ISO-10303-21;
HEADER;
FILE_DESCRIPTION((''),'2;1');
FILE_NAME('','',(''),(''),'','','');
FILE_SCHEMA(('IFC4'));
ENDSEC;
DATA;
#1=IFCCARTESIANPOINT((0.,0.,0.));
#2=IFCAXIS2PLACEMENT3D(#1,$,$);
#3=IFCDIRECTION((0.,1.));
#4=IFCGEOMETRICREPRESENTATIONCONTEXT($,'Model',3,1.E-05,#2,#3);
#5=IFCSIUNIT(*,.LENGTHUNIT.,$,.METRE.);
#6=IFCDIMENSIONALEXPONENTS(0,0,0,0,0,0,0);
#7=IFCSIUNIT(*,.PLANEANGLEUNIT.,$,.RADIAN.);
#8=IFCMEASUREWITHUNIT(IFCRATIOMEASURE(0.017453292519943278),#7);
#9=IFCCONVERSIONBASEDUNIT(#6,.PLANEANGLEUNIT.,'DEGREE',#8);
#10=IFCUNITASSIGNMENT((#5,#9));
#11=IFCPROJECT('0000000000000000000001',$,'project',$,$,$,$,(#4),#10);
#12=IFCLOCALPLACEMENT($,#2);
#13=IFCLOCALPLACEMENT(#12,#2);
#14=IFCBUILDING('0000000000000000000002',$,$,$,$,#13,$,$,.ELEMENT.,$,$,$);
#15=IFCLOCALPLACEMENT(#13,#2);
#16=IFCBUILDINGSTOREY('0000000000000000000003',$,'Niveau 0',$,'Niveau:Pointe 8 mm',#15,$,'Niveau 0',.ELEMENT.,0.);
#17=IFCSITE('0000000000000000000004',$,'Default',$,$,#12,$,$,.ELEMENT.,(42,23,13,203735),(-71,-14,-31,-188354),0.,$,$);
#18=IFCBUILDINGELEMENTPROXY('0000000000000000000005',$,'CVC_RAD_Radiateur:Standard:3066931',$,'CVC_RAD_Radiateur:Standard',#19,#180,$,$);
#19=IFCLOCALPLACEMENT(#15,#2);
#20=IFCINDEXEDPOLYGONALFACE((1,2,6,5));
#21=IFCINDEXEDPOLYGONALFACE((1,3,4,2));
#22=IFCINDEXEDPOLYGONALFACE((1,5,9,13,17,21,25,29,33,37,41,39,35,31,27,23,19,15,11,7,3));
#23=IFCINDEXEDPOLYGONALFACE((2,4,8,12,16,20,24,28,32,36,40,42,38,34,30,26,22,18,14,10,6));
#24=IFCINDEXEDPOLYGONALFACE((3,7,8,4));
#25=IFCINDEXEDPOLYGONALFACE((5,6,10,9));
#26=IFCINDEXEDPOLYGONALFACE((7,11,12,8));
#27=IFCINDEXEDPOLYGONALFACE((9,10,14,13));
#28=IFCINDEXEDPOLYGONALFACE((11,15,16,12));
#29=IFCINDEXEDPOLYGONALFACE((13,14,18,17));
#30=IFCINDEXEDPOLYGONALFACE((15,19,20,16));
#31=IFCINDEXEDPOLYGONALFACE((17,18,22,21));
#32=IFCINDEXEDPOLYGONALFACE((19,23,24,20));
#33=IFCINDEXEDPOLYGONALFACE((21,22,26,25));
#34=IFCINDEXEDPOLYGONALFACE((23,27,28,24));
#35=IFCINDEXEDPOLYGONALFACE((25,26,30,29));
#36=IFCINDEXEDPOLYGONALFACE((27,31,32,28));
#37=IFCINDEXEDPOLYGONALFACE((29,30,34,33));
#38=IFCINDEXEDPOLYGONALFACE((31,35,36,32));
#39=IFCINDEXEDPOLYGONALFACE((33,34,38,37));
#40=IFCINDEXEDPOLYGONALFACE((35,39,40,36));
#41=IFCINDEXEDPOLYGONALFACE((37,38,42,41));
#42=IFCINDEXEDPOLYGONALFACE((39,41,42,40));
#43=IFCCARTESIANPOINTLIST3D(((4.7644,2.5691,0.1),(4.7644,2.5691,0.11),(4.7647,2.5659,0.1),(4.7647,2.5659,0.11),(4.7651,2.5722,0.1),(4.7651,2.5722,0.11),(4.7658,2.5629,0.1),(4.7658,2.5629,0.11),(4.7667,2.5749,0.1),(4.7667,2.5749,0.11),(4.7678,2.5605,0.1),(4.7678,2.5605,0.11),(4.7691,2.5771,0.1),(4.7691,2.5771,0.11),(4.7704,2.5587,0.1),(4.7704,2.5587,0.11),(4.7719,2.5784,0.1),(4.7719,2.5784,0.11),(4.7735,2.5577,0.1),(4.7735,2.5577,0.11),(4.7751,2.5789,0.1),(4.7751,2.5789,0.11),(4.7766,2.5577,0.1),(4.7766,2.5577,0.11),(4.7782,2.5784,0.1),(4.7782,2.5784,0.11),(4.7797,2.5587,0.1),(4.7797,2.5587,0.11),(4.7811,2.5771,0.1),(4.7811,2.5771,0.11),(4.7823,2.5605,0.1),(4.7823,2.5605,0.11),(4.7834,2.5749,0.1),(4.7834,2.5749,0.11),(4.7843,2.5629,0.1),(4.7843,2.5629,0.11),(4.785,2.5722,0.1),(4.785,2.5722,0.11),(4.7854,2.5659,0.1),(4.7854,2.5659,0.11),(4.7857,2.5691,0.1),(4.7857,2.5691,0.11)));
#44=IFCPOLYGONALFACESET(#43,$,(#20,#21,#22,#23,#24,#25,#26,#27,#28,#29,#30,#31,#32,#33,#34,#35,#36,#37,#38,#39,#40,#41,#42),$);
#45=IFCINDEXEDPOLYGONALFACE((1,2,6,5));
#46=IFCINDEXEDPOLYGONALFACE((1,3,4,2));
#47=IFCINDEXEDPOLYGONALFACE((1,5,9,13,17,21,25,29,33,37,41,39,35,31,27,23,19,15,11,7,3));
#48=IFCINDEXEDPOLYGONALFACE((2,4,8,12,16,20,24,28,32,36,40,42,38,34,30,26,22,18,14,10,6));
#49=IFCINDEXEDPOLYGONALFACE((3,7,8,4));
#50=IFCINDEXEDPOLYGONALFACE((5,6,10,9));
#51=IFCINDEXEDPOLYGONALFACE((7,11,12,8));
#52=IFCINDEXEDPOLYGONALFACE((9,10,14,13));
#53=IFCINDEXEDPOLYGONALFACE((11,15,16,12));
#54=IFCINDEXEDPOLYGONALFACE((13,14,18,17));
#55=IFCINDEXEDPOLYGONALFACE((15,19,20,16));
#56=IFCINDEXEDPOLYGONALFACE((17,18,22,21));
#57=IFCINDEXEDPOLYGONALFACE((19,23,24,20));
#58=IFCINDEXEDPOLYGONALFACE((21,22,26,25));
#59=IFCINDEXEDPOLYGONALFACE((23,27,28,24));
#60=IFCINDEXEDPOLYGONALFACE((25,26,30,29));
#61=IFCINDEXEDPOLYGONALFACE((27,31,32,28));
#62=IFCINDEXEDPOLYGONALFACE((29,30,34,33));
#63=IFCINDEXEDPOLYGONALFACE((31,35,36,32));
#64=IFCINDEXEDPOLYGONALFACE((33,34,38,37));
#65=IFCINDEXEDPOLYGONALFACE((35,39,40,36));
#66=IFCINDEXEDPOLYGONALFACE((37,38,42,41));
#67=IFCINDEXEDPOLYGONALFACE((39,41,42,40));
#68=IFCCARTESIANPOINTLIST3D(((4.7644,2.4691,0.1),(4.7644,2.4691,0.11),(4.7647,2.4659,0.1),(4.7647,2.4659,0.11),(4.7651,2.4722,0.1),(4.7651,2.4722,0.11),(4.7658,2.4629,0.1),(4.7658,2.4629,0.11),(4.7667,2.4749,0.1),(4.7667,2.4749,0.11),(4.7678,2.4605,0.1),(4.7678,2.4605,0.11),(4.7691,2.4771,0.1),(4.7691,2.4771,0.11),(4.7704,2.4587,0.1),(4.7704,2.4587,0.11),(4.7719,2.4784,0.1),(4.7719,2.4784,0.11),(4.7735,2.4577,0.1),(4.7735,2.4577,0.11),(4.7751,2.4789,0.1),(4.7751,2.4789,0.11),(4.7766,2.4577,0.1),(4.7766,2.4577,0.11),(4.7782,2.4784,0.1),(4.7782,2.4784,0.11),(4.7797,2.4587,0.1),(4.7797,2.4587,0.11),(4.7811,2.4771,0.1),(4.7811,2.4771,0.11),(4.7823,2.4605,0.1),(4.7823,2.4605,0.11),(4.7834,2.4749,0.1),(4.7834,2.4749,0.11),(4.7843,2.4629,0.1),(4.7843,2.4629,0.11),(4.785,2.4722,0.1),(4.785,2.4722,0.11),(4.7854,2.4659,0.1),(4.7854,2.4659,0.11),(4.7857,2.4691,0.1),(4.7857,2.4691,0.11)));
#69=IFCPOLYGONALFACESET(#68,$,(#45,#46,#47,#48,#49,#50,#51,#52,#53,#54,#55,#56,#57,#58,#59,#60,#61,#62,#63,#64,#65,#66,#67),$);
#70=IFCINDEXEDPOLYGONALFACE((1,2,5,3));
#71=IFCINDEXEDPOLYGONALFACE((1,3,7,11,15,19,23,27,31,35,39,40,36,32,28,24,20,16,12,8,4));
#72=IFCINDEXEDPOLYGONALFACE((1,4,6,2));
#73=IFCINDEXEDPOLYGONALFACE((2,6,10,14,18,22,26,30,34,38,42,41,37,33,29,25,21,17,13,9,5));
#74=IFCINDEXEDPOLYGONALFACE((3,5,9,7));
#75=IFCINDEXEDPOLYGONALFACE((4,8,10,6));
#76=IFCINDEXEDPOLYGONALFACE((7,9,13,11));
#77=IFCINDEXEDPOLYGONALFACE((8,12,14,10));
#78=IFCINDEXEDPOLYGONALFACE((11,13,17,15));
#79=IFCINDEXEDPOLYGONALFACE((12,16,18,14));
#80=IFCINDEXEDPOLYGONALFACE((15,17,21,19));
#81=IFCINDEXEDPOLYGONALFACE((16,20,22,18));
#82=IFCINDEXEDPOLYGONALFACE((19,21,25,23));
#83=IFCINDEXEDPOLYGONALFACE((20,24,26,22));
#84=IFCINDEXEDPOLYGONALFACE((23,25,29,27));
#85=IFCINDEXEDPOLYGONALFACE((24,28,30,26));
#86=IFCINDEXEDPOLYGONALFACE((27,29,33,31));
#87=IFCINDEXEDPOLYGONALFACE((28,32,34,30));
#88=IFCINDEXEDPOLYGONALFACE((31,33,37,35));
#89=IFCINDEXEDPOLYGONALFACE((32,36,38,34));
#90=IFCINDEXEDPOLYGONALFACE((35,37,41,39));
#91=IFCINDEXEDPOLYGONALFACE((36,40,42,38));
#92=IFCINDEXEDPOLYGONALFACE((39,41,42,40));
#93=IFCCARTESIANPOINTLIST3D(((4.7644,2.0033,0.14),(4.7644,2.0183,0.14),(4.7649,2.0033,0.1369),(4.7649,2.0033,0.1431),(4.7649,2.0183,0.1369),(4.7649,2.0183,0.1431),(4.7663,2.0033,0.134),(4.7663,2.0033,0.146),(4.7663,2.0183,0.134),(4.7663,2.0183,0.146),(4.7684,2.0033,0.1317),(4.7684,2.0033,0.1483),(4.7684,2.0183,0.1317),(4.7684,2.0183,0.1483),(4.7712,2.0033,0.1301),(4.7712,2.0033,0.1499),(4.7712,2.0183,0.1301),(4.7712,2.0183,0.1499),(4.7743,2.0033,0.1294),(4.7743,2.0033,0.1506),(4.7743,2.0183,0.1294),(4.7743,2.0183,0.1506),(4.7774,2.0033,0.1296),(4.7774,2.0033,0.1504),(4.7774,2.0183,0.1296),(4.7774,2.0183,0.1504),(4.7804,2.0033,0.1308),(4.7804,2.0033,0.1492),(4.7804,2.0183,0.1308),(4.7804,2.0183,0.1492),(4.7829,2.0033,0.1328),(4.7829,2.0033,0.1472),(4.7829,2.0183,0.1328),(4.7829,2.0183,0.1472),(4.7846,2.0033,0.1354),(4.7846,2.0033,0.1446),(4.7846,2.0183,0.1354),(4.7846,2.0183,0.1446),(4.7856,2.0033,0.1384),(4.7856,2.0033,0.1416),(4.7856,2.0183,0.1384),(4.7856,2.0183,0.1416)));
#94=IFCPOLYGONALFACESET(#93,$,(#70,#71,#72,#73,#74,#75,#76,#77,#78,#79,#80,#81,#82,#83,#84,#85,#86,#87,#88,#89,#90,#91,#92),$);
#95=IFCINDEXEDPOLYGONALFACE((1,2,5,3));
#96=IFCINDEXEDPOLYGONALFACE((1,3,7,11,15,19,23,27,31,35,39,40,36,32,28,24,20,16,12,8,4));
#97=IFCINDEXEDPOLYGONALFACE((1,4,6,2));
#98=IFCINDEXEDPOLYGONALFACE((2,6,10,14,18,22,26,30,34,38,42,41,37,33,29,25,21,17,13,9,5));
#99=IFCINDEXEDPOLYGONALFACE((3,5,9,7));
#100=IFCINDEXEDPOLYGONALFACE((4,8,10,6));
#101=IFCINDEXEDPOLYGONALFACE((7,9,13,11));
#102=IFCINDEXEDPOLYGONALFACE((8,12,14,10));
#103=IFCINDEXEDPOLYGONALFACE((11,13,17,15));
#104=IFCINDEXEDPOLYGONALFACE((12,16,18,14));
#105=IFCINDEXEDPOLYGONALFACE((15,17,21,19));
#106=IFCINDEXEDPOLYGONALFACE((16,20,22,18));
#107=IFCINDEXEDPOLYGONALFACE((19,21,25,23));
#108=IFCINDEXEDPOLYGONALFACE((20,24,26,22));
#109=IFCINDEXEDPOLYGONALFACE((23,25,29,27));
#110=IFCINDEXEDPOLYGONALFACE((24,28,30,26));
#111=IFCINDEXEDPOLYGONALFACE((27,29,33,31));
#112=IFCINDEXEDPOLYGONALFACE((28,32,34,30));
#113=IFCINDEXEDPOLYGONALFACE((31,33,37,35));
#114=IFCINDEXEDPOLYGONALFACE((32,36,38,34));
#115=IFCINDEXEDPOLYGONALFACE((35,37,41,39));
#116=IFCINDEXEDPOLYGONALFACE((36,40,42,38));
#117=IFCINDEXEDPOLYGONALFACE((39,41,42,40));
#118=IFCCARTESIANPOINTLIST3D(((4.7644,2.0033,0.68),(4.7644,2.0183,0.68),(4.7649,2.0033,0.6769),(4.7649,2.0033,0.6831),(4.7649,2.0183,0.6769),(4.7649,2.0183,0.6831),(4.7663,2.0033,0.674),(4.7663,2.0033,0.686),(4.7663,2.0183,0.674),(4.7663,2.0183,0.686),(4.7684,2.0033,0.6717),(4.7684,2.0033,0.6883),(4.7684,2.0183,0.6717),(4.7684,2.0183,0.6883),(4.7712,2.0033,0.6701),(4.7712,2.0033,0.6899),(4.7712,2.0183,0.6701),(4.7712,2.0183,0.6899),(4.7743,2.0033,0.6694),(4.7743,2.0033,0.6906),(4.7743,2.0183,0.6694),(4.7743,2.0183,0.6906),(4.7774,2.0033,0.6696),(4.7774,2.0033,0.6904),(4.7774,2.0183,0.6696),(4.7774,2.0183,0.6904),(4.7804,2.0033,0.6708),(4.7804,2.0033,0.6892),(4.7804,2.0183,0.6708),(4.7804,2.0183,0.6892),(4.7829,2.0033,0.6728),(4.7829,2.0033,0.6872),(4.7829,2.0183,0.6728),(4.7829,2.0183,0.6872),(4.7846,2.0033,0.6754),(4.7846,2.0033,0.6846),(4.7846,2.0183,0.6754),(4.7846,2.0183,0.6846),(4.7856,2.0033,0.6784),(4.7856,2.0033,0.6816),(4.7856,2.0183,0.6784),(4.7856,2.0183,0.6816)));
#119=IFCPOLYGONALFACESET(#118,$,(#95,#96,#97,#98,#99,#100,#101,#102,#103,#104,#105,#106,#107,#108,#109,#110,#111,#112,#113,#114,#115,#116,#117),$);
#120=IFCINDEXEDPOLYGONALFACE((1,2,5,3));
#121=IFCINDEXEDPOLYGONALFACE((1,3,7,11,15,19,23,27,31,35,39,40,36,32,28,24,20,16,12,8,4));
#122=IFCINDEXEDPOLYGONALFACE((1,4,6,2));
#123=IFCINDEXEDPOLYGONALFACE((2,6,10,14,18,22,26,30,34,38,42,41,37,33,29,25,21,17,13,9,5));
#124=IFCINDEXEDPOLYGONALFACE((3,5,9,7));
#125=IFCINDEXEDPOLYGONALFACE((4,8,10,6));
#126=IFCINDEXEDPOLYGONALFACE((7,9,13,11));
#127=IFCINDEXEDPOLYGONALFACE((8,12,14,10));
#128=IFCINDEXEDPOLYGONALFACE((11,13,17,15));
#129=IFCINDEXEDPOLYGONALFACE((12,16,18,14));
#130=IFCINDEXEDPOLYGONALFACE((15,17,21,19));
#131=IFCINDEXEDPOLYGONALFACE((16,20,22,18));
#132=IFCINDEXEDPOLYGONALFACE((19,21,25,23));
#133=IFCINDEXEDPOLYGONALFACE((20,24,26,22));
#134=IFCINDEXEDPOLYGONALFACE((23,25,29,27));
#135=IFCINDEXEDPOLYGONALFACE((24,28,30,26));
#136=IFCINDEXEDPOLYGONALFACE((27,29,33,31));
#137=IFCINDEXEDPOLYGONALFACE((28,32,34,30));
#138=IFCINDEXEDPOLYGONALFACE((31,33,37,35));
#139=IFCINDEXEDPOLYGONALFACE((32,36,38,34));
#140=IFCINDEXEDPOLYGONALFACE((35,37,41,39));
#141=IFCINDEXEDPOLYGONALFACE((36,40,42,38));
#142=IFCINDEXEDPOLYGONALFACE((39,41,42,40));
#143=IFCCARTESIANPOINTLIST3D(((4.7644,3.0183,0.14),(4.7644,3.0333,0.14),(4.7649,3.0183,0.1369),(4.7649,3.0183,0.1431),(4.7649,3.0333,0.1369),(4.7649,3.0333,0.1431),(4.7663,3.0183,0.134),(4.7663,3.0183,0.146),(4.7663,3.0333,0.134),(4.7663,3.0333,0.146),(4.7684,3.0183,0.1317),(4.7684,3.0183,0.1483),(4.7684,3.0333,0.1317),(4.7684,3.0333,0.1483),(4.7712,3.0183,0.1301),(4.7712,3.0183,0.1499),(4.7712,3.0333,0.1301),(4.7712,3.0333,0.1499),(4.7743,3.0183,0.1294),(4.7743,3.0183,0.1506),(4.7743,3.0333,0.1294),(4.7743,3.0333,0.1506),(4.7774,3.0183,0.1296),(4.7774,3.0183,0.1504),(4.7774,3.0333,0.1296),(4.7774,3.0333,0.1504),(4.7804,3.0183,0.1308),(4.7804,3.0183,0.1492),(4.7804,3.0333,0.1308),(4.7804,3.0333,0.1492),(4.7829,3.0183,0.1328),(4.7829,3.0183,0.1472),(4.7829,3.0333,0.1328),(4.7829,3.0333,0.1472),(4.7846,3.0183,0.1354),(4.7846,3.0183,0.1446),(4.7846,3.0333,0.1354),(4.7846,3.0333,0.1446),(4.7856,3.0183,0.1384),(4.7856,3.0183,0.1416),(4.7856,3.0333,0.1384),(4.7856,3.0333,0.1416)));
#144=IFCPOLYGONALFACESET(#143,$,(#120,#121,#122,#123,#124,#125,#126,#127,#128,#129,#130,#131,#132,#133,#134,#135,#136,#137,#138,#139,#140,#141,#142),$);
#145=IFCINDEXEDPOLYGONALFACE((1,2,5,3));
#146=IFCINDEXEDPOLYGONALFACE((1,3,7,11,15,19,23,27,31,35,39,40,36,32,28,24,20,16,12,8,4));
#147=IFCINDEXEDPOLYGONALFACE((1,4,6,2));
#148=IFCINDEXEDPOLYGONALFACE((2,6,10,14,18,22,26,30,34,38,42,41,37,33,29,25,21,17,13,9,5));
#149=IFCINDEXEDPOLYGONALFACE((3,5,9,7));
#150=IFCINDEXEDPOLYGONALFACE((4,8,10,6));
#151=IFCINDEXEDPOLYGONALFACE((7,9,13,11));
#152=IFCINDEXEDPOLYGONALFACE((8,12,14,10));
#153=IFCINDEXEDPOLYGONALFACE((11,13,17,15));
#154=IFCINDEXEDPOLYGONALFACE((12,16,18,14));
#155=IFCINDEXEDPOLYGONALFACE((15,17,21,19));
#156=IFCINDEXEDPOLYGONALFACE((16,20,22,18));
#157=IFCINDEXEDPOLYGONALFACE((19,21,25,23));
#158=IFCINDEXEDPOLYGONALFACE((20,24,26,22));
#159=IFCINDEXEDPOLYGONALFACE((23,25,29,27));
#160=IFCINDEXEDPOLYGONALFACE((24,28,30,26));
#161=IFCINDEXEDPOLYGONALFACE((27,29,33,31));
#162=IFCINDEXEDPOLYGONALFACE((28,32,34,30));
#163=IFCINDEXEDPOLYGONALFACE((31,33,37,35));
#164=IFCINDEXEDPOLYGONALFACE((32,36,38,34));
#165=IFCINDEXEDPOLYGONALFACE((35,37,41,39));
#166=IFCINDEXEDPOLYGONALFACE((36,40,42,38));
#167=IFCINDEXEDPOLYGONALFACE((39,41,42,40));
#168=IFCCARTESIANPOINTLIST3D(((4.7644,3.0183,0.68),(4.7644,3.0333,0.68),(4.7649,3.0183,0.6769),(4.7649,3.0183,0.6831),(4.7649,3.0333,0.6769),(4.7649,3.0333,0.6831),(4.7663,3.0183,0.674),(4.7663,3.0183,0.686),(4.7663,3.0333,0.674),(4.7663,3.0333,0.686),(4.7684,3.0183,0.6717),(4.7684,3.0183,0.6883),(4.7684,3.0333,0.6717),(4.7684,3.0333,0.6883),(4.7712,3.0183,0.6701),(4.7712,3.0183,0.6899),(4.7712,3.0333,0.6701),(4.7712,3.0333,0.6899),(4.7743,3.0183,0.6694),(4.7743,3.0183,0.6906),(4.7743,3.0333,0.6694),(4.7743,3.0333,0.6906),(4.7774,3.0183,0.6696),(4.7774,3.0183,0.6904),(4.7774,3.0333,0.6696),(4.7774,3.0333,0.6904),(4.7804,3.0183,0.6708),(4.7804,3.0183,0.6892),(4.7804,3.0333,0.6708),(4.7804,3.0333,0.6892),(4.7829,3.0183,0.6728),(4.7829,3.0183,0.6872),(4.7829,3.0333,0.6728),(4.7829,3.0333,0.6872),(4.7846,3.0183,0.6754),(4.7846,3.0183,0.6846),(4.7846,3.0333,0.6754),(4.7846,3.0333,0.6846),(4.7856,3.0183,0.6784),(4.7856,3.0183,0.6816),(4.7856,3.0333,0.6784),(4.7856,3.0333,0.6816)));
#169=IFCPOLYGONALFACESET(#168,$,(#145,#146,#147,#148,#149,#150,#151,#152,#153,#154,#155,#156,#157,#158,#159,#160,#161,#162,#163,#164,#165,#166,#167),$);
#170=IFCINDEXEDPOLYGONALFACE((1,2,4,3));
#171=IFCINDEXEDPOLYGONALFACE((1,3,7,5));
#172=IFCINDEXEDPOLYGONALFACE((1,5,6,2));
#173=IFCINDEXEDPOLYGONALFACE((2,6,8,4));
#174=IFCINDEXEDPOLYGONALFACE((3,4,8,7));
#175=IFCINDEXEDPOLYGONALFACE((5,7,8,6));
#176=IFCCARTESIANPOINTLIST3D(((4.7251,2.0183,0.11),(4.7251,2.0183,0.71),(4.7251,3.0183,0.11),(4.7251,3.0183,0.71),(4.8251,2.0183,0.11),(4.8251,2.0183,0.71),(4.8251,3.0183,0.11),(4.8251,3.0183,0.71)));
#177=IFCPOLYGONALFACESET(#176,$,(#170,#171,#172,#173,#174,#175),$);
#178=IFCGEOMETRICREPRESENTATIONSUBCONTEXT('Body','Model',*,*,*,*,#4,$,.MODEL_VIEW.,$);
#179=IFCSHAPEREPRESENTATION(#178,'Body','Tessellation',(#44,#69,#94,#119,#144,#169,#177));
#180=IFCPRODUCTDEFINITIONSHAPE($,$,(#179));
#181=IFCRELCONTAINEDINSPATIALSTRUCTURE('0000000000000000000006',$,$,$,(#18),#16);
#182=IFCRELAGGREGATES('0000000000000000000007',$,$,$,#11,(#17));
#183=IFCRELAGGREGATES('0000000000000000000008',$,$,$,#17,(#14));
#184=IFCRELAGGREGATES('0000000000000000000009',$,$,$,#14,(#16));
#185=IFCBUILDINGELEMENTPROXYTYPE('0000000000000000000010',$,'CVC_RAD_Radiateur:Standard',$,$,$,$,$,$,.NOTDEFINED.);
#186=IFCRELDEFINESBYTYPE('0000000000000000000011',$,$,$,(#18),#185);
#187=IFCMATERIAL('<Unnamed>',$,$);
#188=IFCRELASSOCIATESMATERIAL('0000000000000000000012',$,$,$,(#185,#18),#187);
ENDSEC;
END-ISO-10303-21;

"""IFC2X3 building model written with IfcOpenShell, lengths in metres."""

from ifc_helpers import new_model, entity, si_unit, converted_unit, direction, frame, frame_2d, origin, origin_2d_with_axis, place, context, subcontext, project, spatial, rectangle, circle, extrude, source, transform, mapped, material, type_object, type_shapes, element, save


model = new_model("IFC2X3")

# Units and contexts
model_context = context("Model", 3, precision=1e-05, world=origin(), true_north=direction((0.0, 1.0)))
body_context = subcontext(model_context, "Body", "Model", "MODEL_VIEW")
ifc_project = project(units=[si_unit("LENGTHUNIT", "METRE"), converted_unit("PLANEANGLEUNIT", "DEGREE", entity("IfcRatioMeasure", 0.017453292519943278), si_unit("PLANEANGLEUNIT", "RADIAN"), dimensions=[0, 0, 0, 0, 0, 0, 0])], contexts=[model_context])

# Site, building, storey
site_placement = place(None, origin())
site = spatial("IfcSite", under=ifc_project, at=site_placement, Name="Default", CompositionType="ELEMENT", RefLatitude=(42, 23, 13, 203735), RefLongitude=(-71, -14, -31, -188354), RefElevation=0.0)
building_placement = place(site_placement, origin())
building = spatial("IfcBuilding", under=site, at=building_placement, CompositionType="ELEMENT")
storey_placement = place(building_placement, origin())
storey = spatial("IfcBuildingStorey", under=building, at=storey_placement, Name="Niveau 0", ObjectType="Niveau:Pointe 8 mm", LongName="Niveau 0", CompositionType="ELEMENT", Elevation=0.0)

# Building element proxy
ifc_material = material(Name="<Unnamed>")
building_element_proxy_type = type_object("IfcBuildingElementProxyType", Name="CVC_RAD_Radiateur:Standard", PredefinedType="NOTDEFINED", material=ifc_material)
shared_shape = source(origin(), body_context, "Body", "SweptSolid", [
    extrude(circle(Radius=0.0107, at=frame_2d((0.0, 0.0), x_axis=(1.0, 0.0))), frame((0.05, 0.055, 0.0)), (0.0, 0.0, 1.0), 0.01),
    extrude(circle(Radius=0.0107, at=frame_2d((0.0, 0.0), x_axis=(1.0, 0.0))), frame((-0.05, 0.055, 0.0)), (0.0, 0.0, 1.0), 0.01),
    extrude(circle(Radius=0.0107, at=frame_2d((0.0, 0.0), x_axis=(1.0, 0.0))), frame((-0.515, 0.055, 0.04), z_axis=(1.0, 0.0, 0.0), x_axis=(0.0, 1.0, 0.0)), (0.0, 0.0, 1.0), 0.015),
    extrude(circle(Radius=0.0107, at=frame_2d((0.0, 0.0), x_axis=(1.0, 0.0))), frame((-0.515, 0.055, 0.58), z_axis=(1.0, 0.0, 0.0), x_axis=(0.0, 1.0, 0.0)), (0.0, 0.0, 1.0), 0.015),
    extrude(circle(Radius=0.0107, at=frame_2d((0.0, 0.0), x_axis=(1.0, 0.0))), frame((0.5, 0.055, 0.04), z_axis=(1.0, 0.0, 0.0), x_axis=(0.0, 1.0, 0.0)), (0.0, 0.0, 1.0), 0.015),
    extrude(circle(Radius=0.0107, at=origin_2d_with_axis()), frame((0.5, 0.055, 0.58), z_axis=(1.0, 0.0, 0.0), x_axis=(0.0, 1.0, 0.0)), (0.0, 0.0, 1.0), 0.015),
    extrude(rectangle(XDim=1.0, YDim=0.1, at=origin_2d_with_axis()), frame((0.0, 0.055, 0.01), z_axis=(0.0, 0.0, 1.0), x_axis=(-1.0, 0.0, 0.0)), (0.0, 0.0, 1.0), 0.6),
])
type_shapes(building_element_proxy_type, [shared_shape])
proxy_1_placement = place(storey_placement, frame((4.8301, 2.5183, 0.1), z_axis=(0.0, 0.0, 1.0), x_axis=(0.0, 1.0, 0.0)))
element("IfcBuildingElementProxy", 1, at=proxy_1_placement, inside=storey, type_object=building_element_proxy_type, material=ifc_material, Name="CVC_RAD_Radiateur:Standard:3066931", ObjectType="CVC_RAD_Radiateur:Standard", context=body_context, shape_type="MappedRepresentation", body=[
    mapped(shared_shape, transform((0.0, 0.0, 0.0), scale=1.0)),
])

save(model, "model.ifc")
